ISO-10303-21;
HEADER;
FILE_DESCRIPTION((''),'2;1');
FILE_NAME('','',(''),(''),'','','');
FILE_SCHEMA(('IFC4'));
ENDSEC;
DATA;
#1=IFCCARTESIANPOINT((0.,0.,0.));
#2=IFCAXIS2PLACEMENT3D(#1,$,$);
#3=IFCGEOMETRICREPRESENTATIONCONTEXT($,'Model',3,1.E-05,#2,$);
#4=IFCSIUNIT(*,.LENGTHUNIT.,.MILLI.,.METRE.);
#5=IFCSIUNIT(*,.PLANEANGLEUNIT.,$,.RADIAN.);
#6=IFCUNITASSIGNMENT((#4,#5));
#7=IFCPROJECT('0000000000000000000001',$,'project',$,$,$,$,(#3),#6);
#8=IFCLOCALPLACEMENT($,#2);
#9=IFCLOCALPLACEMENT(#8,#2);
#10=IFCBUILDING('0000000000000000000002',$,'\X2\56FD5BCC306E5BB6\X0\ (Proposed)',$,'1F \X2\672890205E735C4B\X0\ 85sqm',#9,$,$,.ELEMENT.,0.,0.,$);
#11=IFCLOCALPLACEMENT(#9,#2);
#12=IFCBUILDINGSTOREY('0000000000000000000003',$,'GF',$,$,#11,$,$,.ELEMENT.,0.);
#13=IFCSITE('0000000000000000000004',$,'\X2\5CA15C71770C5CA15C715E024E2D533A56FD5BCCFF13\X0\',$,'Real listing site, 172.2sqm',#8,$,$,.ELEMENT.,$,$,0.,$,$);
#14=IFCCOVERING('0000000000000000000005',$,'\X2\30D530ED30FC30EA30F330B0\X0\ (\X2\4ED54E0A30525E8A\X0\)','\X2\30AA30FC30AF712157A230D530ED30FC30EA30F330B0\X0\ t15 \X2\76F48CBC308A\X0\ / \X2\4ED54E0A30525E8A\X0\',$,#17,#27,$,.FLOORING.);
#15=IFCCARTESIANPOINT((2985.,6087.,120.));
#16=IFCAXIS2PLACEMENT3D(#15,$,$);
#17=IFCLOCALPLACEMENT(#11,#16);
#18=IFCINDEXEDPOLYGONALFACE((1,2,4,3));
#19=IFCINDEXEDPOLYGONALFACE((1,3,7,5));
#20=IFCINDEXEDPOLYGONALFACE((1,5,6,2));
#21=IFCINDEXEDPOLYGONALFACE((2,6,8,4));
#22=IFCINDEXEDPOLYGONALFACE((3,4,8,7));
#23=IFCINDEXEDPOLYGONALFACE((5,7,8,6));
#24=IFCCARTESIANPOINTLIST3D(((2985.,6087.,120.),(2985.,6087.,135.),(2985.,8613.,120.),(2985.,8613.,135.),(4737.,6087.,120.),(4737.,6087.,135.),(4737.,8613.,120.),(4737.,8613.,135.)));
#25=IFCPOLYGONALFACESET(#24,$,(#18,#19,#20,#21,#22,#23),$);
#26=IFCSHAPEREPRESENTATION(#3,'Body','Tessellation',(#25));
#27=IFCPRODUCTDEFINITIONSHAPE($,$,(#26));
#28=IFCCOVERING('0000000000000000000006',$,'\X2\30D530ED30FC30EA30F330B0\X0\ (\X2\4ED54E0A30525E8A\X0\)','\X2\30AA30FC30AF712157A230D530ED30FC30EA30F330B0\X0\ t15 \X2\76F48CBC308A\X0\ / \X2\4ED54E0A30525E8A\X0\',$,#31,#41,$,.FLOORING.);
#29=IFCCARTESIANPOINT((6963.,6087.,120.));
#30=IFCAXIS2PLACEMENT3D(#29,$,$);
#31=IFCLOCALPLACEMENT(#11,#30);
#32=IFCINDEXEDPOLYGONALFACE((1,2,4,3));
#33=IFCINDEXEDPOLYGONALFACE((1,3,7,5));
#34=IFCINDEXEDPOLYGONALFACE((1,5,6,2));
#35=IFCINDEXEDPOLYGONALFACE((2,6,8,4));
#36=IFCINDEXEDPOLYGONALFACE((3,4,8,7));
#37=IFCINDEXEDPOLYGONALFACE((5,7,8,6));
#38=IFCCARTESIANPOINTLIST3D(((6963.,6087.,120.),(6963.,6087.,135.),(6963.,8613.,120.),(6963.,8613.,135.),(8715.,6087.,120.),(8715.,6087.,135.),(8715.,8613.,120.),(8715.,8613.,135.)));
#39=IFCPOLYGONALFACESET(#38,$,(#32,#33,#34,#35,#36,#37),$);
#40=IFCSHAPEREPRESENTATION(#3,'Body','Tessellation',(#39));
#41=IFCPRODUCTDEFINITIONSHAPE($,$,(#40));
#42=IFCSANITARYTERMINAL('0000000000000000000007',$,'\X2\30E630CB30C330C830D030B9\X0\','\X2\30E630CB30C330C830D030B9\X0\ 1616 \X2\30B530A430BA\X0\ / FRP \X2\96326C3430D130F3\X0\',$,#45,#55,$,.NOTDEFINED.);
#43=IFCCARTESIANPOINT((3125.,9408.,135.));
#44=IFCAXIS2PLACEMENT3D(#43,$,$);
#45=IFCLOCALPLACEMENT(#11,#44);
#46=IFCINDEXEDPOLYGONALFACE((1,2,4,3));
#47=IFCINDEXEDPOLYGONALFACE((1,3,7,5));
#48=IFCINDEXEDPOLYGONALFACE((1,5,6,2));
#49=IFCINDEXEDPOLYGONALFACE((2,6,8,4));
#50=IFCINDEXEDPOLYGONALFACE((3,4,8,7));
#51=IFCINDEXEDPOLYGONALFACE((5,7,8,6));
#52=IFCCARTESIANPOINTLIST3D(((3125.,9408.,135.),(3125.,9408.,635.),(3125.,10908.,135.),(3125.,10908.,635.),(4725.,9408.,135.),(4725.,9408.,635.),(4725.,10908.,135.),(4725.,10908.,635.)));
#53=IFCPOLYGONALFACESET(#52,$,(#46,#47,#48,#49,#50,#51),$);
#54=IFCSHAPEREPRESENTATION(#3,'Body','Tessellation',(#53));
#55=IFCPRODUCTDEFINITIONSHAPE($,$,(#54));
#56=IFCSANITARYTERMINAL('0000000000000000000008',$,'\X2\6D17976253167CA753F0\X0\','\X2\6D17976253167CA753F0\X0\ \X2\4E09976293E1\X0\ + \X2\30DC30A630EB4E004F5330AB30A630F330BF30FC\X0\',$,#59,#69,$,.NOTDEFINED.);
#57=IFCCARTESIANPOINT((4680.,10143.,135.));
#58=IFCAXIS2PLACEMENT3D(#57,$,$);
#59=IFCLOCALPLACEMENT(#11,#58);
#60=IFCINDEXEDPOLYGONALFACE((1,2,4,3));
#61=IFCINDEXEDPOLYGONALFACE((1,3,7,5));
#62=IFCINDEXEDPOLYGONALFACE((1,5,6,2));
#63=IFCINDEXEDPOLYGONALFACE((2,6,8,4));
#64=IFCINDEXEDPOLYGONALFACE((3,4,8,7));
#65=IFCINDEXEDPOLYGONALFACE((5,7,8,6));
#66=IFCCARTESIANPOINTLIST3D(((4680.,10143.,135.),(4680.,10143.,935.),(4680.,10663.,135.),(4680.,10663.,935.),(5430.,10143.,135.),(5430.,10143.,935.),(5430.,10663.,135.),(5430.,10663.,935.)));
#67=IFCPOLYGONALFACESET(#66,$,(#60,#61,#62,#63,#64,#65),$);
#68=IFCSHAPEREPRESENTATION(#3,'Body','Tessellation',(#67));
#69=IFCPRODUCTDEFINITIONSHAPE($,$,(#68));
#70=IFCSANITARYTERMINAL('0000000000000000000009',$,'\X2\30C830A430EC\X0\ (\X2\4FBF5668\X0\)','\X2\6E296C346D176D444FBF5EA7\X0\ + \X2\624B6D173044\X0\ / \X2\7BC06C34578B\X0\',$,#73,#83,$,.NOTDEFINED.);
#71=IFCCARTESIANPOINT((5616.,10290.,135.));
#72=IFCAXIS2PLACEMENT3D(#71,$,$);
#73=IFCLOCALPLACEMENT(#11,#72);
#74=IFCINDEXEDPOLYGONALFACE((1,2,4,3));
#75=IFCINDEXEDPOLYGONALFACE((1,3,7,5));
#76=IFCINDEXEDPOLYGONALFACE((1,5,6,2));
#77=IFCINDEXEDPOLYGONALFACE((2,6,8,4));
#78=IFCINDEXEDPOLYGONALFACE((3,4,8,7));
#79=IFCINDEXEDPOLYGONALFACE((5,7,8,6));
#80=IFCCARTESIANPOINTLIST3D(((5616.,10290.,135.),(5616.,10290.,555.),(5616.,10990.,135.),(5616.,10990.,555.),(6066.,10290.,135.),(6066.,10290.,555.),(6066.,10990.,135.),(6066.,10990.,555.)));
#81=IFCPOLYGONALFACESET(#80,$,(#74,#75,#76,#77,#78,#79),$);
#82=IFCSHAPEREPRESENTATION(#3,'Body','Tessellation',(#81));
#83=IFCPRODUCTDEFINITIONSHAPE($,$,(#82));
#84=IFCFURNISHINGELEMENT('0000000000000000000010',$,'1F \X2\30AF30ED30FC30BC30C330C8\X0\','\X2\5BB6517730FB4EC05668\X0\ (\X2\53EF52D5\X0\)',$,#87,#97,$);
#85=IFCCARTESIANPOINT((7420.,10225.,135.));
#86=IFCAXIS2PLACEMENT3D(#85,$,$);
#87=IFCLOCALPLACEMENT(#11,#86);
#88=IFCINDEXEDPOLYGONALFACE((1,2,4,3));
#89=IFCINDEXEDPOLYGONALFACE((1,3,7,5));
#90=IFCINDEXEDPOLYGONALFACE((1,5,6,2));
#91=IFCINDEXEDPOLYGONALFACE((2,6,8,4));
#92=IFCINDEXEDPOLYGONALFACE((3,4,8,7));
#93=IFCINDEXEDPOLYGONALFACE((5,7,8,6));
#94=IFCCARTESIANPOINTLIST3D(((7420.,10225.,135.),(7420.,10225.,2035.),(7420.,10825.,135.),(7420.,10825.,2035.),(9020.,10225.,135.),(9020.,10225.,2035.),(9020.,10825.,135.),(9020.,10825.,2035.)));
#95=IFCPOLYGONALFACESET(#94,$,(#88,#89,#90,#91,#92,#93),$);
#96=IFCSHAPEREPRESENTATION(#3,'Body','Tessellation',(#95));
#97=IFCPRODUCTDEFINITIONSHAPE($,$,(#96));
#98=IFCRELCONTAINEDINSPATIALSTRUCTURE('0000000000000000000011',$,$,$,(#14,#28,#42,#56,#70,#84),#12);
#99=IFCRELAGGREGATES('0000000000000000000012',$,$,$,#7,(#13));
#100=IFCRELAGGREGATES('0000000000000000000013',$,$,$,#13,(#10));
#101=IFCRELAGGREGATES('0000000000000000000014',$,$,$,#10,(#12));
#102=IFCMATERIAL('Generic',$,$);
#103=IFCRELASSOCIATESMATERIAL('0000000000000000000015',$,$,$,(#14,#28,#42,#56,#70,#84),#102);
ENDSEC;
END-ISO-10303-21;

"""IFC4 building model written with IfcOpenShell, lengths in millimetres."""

from ifc_helpers import new_model, si_unit, frame, frame_2d, origin, place, context, project, spatial, rectangle, extrude, material, element, save


model = new_model("IFC4")

# Units and contexts
model_context = context("Model", 3, precision=1e-05, world=origin())
ifc_project = project(units=[si_unit("LENGTHUNIT", "METRE", prefix="MILLI"), si_unit("PLANEANGLEUNIT", "RADIAN")], contexts=[model_context])

# Site, building, storey
site_placement = place(None, origin())
site = spatial("IfcSite", under=ifc_project, at=site_placement, Name="岡山県岡山市中区国富３", ObjectType="Real listing site, 172.2sqm", CompositionType="ELEMENT", RefElevation=0.0)
building_placement = place(site_placement, origin())
building = spatial("IfcBuilding", under=site, at=building_placement, Name="国富の家 (Proposed)", ObjectType="1F 木造平屋 85sqm", CompositionType="ELEMENT", ElevationOfRefHeight=0.0, ElevationOfTerrain=0.0)
storey_placement = place(building_placement, origin())
storey = spatial("IfcBuildingStorey", under=building, at=storey_placement, Name="GF", CompositionType="ELEMENT", Elevation=0.0)

# Coverings
ifc_material_1 = material(Name="Generic")
covering_1_placement = place(storey_placement, frame((2985.0, 6087.0, 120.0)))
element("IfcCovering", 1, at=covering_1_placement, inside=storey, material=ifc_material_1, Name="フローリング (仕上げ床)", Description="オーク無垢フローリング t15 直貼り / 仕上げ床", PredefinedType="FLOORING", context=model_context, shape_type="SweptSolid", body=[
    extrude(rectangle(XDim=1752.0, YDim=2526.0, at=frame_2d((876.0, 1263.0))), frame((2985.0, 6087.0, 120.0)), (0.0, 0.0, 1.0), 15.0),
])
covering_2_placement = place(storey_placement, frame((6963.0, 6087.0, 120.0)))
element("IfcCovering", 2, at=covering_2_placement, inside=storey, material=ifc_material_1, Name="フローリング (仕上げ床)", Description="オーク無垢フローリング t15 直貼り / 仕上げ床", PredefinedType="FLOORING", context=model_context, shape_type="SweptSolid", body=[
    extrude(rectangle(XDim=1752.0, YDim=2526.0, at=frame_2d((876.0, 1263.0))), frame((6963.0, 6087.0, 120.0)), (0.0, 0.0, 1.0), 15.0),
])

# Sanitary terminals
sanitary_terminal_1_placement = place(storey_placement, frame((3125.0, 9408.0, 135.0)))
element("IfcSanitaryTerminal", 3, at=sanitary_terminal_1_placement, inside=storey, material=ifc_material_1, Name="ユニットバス", Description="ユニットバス 1616 サイズ / FRP 防水パン", PredefinedType="NOTDEFINED", context=model_context, shape_type="SweptSolid", body=[
    extrude(rectangle(XDim=1600.0, YDim=1500.0, at=frame_2d((800.0, 750.0))), frame((3125.0, 9408.0, 135.0)), (0.0, 0.0, 1.0), 500.0),
])
sanitary_terminal_2_placement = place(storey_placement, frame((4680.0, 10143.0, 135.0)))
element("IfcSanitaryTerminal", 4, at=sanitary_terminal_2_placement, inside=storey, material=ifc_material_1, Name="洗面化粧台", Description="洗面化粧台 三面鏡 + ボウル一体カウンター", PredefinedType="NOTDEFINED", context=model_context, shape_type="SweptSolid", body=[
    extrude(rectangle(XDim=750.0, YDim=520.0, at=frame_2d((375.0, 260.0))), frame((4680.0, 10143.0, 135.0)), (0.0, 0.0, 1.0), 800.0),
])
sanitary_terminal_3_placement = place(storey_placement, frame((5616.0, 10290.0, 135.0)))
element("IfcSanitaryTerminal", 5, at=sanitary_terminal_3_placement, inside=storey, material=ifc_material_1, Name="トイレ (便器)", Description="温水洗浄便座 + 手洗い / 節水型", PredefinedType="NOTDEFINED", context=model_context, shape_type="SweptSolid", body=[
    extrude(rectangle(XDim=450.0, YDim=700.0, at=frame_2d((225.0, 350.0))), frame((5616.0, 10290.0, 135.0)), (0.0, 0.0, 1.0), 420.0),
])

# Furnishing element
furnishing_placement = place(storey_placement, frame((7420.0, 10225.0, 135.0)))
element("IfcFurnishingElement", 6, at=furnishing_placement, inside=storey, material=ifc_material_1, Name="1F クローゼット", Description="家具・什器 (可動)", context=model_context, shape_type="SweptSolid", body=[
    extrude(rectangle(XDim=1600.0, YDim=600.0, at=frame_2d((800.0, 300.0))), frame((7420.0, 10225.0, 135.0)), (0.0, 0.0, 1.0), 1900.0),
])

save(model, "model.ifc")
